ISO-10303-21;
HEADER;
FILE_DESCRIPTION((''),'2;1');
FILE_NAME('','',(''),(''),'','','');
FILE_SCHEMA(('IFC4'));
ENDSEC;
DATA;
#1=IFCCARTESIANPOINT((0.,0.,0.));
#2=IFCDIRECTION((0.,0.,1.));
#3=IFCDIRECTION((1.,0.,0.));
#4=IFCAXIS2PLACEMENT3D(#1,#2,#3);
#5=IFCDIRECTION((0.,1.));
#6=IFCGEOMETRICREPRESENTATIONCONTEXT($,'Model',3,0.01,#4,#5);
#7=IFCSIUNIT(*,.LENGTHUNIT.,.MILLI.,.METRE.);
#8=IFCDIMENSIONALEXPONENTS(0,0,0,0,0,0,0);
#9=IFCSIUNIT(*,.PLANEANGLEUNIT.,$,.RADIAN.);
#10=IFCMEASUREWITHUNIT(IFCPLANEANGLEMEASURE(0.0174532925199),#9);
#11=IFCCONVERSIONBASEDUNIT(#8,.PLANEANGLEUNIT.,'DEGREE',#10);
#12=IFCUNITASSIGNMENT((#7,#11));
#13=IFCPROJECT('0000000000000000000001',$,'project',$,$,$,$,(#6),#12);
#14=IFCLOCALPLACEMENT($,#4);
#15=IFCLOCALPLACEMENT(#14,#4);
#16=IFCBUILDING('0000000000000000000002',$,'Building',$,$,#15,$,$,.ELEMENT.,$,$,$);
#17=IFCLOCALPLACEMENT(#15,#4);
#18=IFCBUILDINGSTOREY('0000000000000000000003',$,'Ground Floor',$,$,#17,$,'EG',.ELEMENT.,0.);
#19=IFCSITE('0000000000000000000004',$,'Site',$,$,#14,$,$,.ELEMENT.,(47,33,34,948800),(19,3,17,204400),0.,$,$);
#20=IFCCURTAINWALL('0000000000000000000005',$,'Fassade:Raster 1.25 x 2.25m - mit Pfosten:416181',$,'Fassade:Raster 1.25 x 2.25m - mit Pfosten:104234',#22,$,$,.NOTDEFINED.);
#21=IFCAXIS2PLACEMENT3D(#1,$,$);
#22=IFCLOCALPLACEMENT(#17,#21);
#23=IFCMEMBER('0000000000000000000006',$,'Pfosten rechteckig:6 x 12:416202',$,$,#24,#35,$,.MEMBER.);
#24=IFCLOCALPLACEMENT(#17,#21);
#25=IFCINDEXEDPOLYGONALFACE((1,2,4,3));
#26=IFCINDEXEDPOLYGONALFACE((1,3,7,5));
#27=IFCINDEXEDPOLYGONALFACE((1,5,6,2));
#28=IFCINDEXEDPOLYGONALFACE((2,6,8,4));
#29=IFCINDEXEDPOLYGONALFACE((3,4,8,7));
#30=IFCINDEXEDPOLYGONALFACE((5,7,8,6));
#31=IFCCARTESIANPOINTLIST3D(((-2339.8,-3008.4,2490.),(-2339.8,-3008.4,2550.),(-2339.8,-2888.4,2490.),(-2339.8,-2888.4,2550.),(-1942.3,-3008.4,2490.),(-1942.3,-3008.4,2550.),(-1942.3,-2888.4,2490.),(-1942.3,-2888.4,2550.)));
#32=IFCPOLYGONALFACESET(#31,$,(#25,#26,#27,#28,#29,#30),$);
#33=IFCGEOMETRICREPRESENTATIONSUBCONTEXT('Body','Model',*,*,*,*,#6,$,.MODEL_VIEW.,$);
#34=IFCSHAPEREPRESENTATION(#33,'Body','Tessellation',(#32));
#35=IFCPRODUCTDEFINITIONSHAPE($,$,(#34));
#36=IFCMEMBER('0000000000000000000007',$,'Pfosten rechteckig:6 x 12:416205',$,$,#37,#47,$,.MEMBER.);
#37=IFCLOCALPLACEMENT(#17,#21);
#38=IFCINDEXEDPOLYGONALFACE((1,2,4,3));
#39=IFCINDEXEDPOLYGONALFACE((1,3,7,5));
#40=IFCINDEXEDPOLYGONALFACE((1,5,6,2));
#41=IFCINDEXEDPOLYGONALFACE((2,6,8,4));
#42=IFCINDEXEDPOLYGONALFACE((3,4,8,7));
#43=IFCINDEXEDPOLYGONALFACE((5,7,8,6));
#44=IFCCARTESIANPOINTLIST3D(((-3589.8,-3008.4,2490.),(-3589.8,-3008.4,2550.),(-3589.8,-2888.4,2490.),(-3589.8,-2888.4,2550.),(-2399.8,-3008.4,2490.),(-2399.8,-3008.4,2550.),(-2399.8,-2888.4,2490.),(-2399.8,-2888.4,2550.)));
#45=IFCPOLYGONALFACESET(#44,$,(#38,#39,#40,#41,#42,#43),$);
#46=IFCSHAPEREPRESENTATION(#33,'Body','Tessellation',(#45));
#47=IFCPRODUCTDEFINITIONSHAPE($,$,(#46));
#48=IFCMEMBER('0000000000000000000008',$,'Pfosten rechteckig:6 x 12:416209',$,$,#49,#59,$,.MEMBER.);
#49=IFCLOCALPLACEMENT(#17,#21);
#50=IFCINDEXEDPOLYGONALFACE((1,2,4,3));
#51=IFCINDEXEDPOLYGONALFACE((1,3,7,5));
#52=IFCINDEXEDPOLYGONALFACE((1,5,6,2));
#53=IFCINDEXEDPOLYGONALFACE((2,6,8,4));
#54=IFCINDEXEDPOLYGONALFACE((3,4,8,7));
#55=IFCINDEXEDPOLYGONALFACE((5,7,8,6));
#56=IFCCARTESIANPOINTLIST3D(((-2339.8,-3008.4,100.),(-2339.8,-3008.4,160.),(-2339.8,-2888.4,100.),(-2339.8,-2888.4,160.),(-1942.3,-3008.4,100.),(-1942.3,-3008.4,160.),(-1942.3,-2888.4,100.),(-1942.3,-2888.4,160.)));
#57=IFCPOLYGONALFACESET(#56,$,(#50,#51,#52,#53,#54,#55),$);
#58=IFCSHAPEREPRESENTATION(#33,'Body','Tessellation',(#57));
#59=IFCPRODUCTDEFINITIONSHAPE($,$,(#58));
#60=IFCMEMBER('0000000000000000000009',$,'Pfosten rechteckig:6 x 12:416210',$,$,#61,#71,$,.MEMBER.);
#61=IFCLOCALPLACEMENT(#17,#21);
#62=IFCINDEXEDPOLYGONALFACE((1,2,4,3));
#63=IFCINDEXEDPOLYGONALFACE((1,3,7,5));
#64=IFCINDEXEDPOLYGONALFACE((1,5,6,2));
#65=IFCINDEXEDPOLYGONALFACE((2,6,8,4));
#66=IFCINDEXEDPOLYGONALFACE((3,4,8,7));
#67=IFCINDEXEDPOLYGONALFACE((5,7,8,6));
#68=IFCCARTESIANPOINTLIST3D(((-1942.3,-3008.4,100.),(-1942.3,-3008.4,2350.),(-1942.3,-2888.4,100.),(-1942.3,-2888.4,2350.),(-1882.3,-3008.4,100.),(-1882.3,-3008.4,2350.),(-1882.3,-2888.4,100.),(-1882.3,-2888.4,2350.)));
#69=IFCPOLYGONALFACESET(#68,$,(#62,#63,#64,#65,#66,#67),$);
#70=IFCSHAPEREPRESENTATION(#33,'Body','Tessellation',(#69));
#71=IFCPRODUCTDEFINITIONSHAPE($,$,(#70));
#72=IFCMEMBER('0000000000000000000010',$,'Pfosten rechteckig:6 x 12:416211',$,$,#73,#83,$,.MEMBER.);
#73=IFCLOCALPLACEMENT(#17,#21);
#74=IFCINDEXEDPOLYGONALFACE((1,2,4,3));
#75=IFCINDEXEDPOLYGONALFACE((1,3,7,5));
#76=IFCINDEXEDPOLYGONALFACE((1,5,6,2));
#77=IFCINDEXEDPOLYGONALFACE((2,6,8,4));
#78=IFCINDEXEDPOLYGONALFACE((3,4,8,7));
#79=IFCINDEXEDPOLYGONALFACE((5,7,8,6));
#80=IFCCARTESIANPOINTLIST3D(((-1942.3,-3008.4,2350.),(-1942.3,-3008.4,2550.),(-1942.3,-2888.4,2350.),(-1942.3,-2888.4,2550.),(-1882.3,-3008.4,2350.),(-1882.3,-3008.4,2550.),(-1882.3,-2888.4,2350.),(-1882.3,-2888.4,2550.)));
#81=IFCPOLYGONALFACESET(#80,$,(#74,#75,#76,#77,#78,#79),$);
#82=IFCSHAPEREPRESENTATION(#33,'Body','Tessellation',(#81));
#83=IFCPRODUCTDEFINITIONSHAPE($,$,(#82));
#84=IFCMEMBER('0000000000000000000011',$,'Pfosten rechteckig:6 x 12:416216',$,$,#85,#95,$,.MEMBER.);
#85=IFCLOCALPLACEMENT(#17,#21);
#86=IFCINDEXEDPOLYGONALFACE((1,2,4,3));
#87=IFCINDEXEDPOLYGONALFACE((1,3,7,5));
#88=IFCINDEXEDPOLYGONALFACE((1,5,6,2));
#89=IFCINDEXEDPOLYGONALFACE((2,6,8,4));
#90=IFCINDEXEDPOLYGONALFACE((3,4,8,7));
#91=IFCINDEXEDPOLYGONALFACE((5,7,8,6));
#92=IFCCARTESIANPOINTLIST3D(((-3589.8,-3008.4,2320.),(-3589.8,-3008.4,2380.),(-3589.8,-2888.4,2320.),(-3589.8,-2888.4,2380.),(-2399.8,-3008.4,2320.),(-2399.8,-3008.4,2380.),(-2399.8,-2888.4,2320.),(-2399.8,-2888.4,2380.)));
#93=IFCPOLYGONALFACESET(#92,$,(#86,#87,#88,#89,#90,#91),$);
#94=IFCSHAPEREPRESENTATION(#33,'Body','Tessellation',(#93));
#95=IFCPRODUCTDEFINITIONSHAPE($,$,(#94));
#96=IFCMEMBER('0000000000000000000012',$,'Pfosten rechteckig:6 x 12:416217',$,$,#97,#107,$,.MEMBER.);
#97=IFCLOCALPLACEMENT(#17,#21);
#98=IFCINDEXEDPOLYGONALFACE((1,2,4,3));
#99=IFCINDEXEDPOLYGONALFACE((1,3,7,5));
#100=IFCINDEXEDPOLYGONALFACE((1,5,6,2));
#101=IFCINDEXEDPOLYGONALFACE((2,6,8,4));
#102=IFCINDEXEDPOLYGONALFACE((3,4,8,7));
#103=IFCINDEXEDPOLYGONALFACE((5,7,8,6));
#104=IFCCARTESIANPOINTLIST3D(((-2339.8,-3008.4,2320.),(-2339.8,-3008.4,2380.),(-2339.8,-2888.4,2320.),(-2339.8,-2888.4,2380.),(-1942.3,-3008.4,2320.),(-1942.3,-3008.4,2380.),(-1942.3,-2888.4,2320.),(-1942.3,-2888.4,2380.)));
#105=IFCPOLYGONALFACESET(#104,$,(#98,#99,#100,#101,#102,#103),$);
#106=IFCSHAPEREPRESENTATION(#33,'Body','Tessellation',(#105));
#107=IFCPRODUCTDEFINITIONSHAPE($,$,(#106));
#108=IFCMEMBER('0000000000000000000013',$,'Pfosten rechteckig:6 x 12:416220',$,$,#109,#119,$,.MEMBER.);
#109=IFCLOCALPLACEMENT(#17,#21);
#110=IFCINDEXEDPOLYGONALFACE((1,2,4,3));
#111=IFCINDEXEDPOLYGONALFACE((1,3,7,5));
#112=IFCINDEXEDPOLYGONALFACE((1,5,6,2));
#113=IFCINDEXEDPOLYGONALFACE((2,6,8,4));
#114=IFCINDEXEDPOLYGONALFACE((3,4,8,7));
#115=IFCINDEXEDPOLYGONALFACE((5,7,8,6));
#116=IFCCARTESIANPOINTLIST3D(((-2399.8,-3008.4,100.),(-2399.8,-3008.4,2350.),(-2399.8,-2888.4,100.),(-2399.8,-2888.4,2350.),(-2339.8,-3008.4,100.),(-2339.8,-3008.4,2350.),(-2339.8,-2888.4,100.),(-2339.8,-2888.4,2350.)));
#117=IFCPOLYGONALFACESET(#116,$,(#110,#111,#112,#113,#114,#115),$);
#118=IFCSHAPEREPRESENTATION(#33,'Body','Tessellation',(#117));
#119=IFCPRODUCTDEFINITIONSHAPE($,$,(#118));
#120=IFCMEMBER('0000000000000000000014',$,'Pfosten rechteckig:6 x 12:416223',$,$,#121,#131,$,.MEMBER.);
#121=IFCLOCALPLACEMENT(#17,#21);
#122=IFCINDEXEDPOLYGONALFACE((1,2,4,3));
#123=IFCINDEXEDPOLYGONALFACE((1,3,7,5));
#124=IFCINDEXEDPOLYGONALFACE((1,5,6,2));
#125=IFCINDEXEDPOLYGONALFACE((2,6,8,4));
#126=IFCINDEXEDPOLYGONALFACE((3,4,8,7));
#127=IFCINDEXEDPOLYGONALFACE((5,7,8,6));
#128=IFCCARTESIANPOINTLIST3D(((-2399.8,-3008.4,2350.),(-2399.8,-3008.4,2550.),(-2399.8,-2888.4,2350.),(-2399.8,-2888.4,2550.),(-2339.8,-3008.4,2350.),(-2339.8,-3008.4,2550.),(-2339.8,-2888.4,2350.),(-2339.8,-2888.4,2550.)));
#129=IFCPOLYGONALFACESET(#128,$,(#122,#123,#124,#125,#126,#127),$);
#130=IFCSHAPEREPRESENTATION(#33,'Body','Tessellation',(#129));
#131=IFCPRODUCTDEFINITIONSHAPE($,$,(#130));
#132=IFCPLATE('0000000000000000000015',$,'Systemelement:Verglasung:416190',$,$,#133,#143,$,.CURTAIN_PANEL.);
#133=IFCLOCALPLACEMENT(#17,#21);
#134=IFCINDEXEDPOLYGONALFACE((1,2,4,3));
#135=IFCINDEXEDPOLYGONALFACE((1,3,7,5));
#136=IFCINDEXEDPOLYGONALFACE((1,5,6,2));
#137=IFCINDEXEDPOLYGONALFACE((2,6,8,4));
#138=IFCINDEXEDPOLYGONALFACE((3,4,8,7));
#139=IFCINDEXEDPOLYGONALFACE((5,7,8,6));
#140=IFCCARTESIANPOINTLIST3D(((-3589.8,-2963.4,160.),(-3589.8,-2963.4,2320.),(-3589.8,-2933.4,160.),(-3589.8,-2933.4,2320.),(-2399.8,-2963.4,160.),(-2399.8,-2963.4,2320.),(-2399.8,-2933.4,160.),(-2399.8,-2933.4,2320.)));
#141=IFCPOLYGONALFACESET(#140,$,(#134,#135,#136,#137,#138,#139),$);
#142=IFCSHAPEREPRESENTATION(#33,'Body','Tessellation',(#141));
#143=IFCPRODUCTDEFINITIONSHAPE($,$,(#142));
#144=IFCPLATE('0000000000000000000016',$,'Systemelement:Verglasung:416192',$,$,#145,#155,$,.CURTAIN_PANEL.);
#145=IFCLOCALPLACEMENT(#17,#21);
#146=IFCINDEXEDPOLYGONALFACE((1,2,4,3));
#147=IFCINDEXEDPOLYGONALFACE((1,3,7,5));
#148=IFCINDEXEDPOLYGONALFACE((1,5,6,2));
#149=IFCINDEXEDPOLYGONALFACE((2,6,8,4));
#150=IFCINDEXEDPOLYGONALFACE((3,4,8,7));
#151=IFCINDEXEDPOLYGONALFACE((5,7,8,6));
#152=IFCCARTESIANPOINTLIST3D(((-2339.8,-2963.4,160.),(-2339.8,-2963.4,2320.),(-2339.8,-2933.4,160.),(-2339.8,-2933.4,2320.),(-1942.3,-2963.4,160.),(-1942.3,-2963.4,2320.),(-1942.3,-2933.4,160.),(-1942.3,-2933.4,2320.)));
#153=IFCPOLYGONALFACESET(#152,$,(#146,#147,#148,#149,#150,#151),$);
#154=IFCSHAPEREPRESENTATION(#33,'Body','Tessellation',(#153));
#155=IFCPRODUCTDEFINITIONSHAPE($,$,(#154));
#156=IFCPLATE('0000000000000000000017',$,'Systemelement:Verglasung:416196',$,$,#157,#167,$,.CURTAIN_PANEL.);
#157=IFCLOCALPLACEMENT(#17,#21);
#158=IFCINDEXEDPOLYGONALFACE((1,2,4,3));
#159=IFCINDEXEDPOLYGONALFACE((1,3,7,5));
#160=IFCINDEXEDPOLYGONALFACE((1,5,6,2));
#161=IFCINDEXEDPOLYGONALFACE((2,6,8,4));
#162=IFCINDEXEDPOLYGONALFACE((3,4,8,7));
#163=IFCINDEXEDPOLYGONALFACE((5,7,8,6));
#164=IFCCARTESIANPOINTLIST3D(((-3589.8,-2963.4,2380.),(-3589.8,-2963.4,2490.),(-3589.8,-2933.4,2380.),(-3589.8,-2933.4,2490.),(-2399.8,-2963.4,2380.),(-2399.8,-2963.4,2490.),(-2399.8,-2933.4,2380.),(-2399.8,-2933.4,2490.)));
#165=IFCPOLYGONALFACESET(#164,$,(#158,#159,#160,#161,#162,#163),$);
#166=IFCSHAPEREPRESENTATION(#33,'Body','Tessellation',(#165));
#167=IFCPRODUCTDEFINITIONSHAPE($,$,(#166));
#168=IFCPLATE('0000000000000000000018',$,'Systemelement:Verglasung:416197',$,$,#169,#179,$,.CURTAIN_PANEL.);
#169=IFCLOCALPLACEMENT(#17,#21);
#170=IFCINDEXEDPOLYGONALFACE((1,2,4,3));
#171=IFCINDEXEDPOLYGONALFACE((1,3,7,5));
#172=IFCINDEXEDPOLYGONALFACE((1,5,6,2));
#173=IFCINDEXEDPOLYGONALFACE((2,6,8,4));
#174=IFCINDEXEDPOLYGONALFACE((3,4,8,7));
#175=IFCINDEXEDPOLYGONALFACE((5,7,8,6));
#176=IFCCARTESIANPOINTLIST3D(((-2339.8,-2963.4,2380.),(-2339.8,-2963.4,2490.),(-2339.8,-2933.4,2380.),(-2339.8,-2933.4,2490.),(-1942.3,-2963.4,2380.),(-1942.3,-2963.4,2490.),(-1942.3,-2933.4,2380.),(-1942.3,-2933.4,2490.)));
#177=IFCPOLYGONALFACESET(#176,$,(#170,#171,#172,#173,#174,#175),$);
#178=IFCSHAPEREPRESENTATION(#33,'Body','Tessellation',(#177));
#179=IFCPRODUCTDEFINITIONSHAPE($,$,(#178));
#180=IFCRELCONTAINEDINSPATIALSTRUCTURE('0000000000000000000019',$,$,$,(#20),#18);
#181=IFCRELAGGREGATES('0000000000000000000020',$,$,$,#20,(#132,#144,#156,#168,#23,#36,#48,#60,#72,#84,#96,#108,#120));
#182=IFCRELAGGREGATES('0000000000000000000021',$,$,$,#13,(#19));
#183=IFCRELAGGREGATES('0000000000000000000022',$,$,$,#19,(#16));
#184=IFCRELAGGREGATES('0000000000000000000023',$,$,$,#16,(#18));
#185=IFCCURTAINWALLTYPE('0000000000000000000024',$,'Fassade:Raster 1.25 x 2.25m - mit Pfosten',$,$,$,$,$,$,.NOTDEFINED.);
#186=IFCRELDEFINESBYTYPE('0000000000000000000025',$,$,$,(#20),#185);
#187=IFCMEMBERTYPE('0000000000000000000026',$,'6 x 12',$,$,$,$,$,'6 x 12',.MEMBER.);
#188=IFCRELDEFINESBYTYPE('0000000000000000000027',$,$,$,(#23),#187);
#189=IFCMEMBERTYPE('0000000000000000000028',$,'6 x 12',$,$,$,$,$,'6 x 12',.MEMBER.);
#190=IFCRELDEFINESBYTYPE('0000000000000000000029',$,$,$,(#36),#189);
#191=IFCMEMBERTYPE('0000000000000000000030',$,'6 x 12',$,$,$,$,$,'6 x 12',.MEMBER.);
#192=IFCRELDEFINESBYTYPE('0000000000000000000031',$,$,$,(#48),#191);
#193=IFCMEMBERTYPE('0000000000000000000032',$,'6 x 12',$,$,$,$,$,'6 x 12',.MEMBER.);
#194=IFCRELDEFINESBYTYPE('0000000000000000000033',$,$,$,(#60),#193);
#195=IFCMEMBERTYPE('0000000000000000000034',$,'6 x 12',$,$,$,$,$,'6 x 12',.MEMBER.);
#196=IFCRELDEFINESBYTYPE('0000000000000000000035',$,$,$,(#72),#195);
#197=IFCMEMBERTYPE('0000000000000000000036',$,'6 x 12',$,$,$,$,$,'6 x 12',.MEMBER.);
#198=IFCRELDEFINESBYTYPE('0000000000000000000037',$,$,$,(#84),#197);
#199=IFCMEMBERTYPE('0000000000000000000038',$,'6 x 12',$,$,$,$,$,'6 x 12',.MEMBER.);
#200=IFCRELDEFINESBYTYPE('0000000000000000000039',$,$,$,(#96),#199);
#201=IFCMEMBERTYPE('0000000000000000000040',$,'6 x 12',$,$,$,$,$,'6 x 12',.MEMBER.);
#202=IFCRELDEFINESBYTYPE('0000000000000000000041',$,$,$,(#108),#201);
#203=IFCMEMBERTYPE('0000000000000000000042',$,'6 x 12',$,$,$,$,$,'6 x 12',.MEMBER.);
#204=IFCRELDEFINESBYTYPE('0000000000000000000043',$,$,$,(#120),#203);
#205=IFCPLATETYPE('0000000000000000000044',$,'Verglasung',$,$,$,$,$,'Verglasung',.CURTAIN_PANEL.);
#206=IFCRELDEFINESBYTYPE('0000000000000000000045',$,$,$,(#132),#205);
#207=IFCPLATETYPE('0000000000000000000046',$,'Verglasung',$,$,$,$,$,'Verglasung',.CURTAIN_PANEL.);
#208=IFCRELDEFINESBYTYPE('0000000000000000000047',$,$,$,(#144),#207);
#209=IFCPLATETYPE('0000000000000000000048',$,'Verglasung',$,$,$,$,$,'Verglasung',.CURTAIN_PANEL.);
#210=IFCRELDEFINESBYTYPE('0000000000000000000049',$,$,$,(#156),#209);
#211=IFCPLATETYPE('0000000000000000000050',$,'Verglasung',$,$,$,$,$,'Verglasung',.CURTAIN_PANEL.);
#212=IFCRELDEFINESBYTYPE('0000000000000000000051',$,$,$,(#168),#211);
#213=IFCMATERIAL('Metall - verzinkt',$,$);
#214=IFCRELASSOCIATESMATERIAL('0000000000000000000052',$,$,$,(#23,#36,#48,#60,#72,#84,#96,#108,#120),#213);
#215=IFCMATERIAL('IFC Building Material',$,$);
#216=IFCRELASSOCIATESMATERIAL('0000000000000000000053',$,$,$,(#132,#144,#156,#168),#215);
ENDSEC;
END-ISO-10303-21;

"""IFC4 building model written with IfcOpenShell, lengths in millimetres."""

from ifc_helpers import new_model, entity, si_unit, converted_unit, direction, frame, origin_with_axes, origin_2d_with_axis, place, context, subcontext, project, spatial, rectangle, extrude, material, type_object, element, aggregate, save


model = new_model("IFC4")

# Units and contexts
model_context = context("Model", 3, precision=0.01, world=origin_with_axes(), true_north=direction((0.0, 1.0)))
body_context = subcontext(model_context, "Body", "Model", "MODEL_VIEW")
ifc_project = project(units=[si_unit("LENGTHUNIT", "METRE", prefix="MILLI"), converted_unit("PLANEANGLEUNIT", "DEGREE", entity("IfcPlaneAngleMeasure", 0.0174532925199), si_unit("PLANEANGLEUNIT", "RADIAN"), dimensions=[0, 0, 0, 0, 0, 0, 0])], contexts=[model_context])

# Site, building, storey
site_placement = place(None, origin_with_axes())
site = spatial("IfcSite", under=ifc_project, at=site_placement, Name="Site", CompositionType="ELEMENT", RefLatitude=(47, 33, 34, 948800), RefLongitude=(19, 3, 17, 204400), RefElevation=0.0)
building_placement = place(site_placement, origin_with_axes())
building = spatial("IfcBuilding", under=site, at=building_placement, Name="Building", CompositionType="ELEMENT")
storey_placement = place(building_placement, origin_with_axes())
storey = spatial("IfcBuildingStorey", under=building, at=storey_placement, Name="Ground Floor", LongName="EG", CompositionType="ELEMENT", Elevation=0.0)

# Curtain wall, members, plates
curtain_wall_type = type_object("IfcCurtainWallType", Name="Fassade:Raster 1.25 x 2.25m - mit Pfosten", PredefinedType="NOTDEFINED")
curtain_wall_placement = place(storey_placement, origin_with_axes())
curtain_wall = element("IfcCurtainWall", 1, at=curtain_wall_placement, inside=storey, type_object=curtain_wall_type, Name="Fassade:Raster 1.25 x 2.25m - mit Pfosten:416181", ObjectType="Fassade:Raster 1.25 x 2.25m - mit Pfosten:104234", PredefinedType="NOTDEFINED")
ifc_material_1 = material(Name="Metall - verzinkt")
member_type_1 = type_object("IfcMemberType", Name="6 x 12", ElementType="6 x 12", PredefinedType="MEMBER")
member_1_placement = place(curtain_wall_placement, frame((-1942.3, -2948.4, 2550.0), z_axis=(0.0, 0.0, 1.0), x_axis=(0.0, -1.0, 0.0)))
member_1 = element("IfcMember", 2, at=member_1_placement, type_object=member_type_1, material=ifc_material_1, Name="Pfosten rechteckig:6 x 12:416202", PredefinedType="MEMBER", context=body_context, shape_type="SweptSolid", body=[
    extrude(rectangle(XDim=120.0, YDim=60.0, at=origin_2d_with_axis()), frame((0.0, -397.5, -30.0), z_axis=(0.0, 1.0, 0.0), x_axis=(-1.0, 0.0, 0.0)), (0.0, 0.0, 1.0), 397.5),
])
member_type_2 = type_object("IfcMemberType", Name="6 x 12", ElementType="6 x 12", PredefinedType="MEMBER")
member_2_placement = place(curtain_wall_placement, frame((-2399.8, -2948.4, 2550.0), z_axis=(0.0, 0.0, 1.0), x_axis=(0.0, -1.0, 0.0)))
member_2 = element("IfcMember", 3, at=member_2_placement, type_object=member_type_2, material=ifc_material_1, Name="Pfosten rechteckig:6 x 12:416205", PredefinedType="MEMBER", context=body_context, shape_type="SweptSolid", body=[
    extrude(rectangle(XDim=120.0, YDim=60.0, at=origin_2d_with_axis()), frame((0.0, -1190.0, -30.0), z_axis=(0.0, 1.0, 0.0), x_axis=(-1.0, 0.0, 0.0)), (0.0, 0.0, 1.0), 1190.0),
])
member_type_3 = type_object("IfcMemberType", Name="6 x 12", ElementType="6 x 12", PredefinedType="MEMBER")
member_3_placement = place(curtain_wall_placement, frame((-2339.8, -2948.4, 100.0), z_axis=(0.0, 0.0, 1.0), x_axis=(0.0, -1.0, 0.0)))
member_3 = element("IfcMember", 4, at=member_3_placement, type_object=member_type_3, material=ifc_material_1, Name="Pfosten rechteckig:6 x 12:416209", PredefinedType="MEMBER", context=body_context, shape_type="SweptSolid", body=[
    extrude(rectangle(XDim=120.0, YDim=60.0, at=origin_2d_with_axis()), frame((0.0, 397.5, 30.0), z_axis=(0.0, -1.0, 0.0), x_axis=(-1.0, 0.0, 0.0)), (0.0, 0.0, 1.0), 397.5),
])
member_type_4 = type_object("IfcMemberType", Name="6 x 12", ElementType="6 x 12", PredefinedType="MEMBER")
member_4_placement = place(curtain_wall_placement, frame((-1882.3, -2948.4, 100.0), z_axis=(0.0, 0.0, 1.0), x_axis=(1.0, 0.0, 0.0)))
member_4 = element("IfcMember", 5, at=member_4_placement, type_object=member_type_4, material=ifc_material_1, Name="Pfosten rechteckig:6 x 12:416210", PredefinedType="MEMBER", context=body_context, shape_type="SweptSolid", body=[
    extrude(rectangle(XDim=120.0, YDim=60.0, at=origin_2d_with_axis()), frame((-30.0, 0.0, 2250.0), z_axis=(0.0, 0.0, -1.0), x_axis=(0.0, 1.0, 0.0)), (0.0, 0.0, 1.0), 2250.0),
])
member_type_5 = type_object("IfcMemberType", Name="6 x 12", ElementType="6 x 12", PredefinedType="MEMBER")
member_5_placement = place(curtain_wall_placement, frame((-1882.3, -2948.4, 2350.0), z_axis=(0.0, 0.0, 1.0), x_axis=(1.0, 0.0, 0.0)))
member_5 = element("IfcMember", 6, at=member_5_placement, type_object=member_type_5, material=ifc_material_1, Name="Pfosten rechteckig:6 x 12:416211", PredefinedType="MEMBER", context=body_context, shape_type="SweptSolid", body=[
    extrude(rectangle(XDim=120.0, YDim=60.0, at=origin_2d_with_axis()), frame((-30.0, 0.0, 200.0), z_axis=(0.0, 0.0, -1.0), x_axis=(0.0, 1.0, 0.0)), (0.0, 0.0, 1.0), 200.0),
])
member_type_6 = type_object("IfcMemberType", Name="6 x 12", ElementType="6 x 12", PredefinedType="MEMBER")
member_6_placement = place(curtain_wall_placement, frame((-2399.8, -2948.4, 2350.0), z_axis=(0.0, 0.0, 1.0), x_axis=(0.0, -1.0, 0.0)))
member_6 = element("IfcMember", 7, at=member_6_placement, type_object=member_type_6, material=ifc_material_1, Name="Pfosten rechteckig:6 x 12:416216", PredefinedType="MEMBER", context=body_context, shape_type="SweptSolid", body=[
    extrude(rectangle(XDim=120.0, YDim=60.0, at=origin_2d_with_axis()), frame((0.0, -1190.0, 0.0), z_axis=(0.0, 1.0, 0.0), x_axis=(-1.0, 0.0, 0.0)), (0.0, 0.0, 1.0), 1190.0),
])
member_type_7 = type_object("IfcMemberType", Name="6 x 12", ElementType="6 x 12", PredefinedType="MEMBER")
member_7_placement = place(curtain_wall_placement, frame((-1942.3, -2948.4, 2350.0), z_axis=(0.0, 0.0, 1.0), x_axis=(0.0, -1.0, 0.0)))
member_7 = element("IfcMember", 8, at=member_7_placement, type_object=member_type_7, material=ifc_material_1, Name="Pfosten rechteckig:6 x 12:416217", PredefinedType="MEMBER", context=body_context, shape_type="SweptSolid", body=[
    extrude(rectangle(XDim=120.0, YDim=60.0, at=origin_2d_with_axis()), frame((0.0, -397.5, 0.0), z_axis=(0.0, 1.0, 0.0), x_axis=(-1.0, 0.0, 0.0)), (0.0, 0.0, 1.0), 397.5),
])
member_type_8 = type_object("IfcMemberType", Name="6 x 12", ElementType="6 x 12", PredefinedType="MEMBER")
member_8_placement = place(curtain_wall_placement, frame((-2369.8, -2948.4, 100.0), z_axis=(0.0, 0.0, 1.0), x_axis=(1.0, 0.0, 0.0)))
member_8 = element("IfcMember", 9, at=member_8_placement, type_object=member_type_8, material=ifc_material_1, Name="Pfosten rechteckig:6 x 12:416220", PredefinedType="MEMBER", context=body_context, shape_type="SweptSolid", body=[
    extrude(rectangle(XDim=120.0, YDim=60.0, at=origin_2d_with_axis()), frame((0.0, 0.0, 2250.0), z_axis=(0.0, 0.0, -1.0), x_axis=(0.0, 1.0, 0.0)), (0.0, 0.0, 1.0), 2250.0),
])
member_type_9 = type_object("IfcMemberType", Name="6 x 12", ElementType="6 x 12", PredefinedType="MEMBER")
member_9_placement = place(curtain_wall_placement, frame((-2369.8, -2948.4, 2350.0), z_axis=(0.0, 0.0, 1.0), x_axis=(1.0, 0.0, 0.0)))
member_9 = element("IfcMember", 10, at=member_9_placement, type_object=member_type_9, material=ifc_material_1, Name="Pfosten rechteckig:6 x 12:416223", PredefinedType="MEMBER", context=body_context, shape_type="SweptSolid", body=[
    extrude(rectangle(XDim=120.0, YDim=60.0, at=origin_2d_with_axis()), frame((0.0, 0.0, 200.0), z_axis=(0.0, 0.0, -1.0), x_axis=(0.0, 1.0, 0.0)), (0.0, 0.0, 1.0), 200.0),
])
ifc_material_2 = material(Name="IFC Building Material")
plate_type_1 = type_object("IfcPlateType", Name="Verglasung", ElementType="Verglasung", PredefinedType="CURTAIN_PANEL")
plate_1_placement = place(curtain_wall_placement, frame((-2994.8, -2948.4, 160.0), z_axis=(0.0, 0.0, 1.0), x_axis=(1.0, 0.0, 0.0)))
plate_1 = element("IfcPlate", 11, at=plate_1_placement, type_object=plate_type_1, material=ifc_material_2, Name="Systemelement:Verglasung:416190", PredefinedType="CURTAIN_PANEL", context=body_context, shape_type="SweptSolid", body=[
    extrude(rectangle(XDim=30.0, YDim=1190.0, at=origin_2d_with_axis()), frame((0.0, 0.0, 0.0), z_axis=(0.0, 0.0, 1.0), x_axis=(0.0, 1.0, 0.0)), (0.0, 0.0, 1.0), 2160.0),
])
plate_type_2 = type_object("IfcPlateType", Name="Verglasung", ElementType="Verglasung", PredefinedType="CURTAIN_PANEL")
plate_2_placement = place(curtain_wall_placement, frame((-2141.0, -2948.4, 160.0), z_axis=(0.0, 0.0, 1.0), x_axis=(1.0, 0.0, 0.0)))
plate_2 = element("IfcPlate", 12, at=plate_2_placement, type_object=plate_type_2, material=ifc_material_2, Name="Systemelement:Verglasung:416192", PredefinedType="CURTAIN_PANEL", context=body_context, shape_type="SweptSolid", body=[
    extrude(rectangle(XDim=30.0, YDim=397.5, at=origin_2d_with_axis()), frame((0.0, 0.0, 0.0), z_axis=(0.0, 0.0, 1.0), x_axis=(0.0, 1.0, 0.0)), (0.0, 0.0, 1.0), 2160.0),
])
plate_type_3 = type_object("IfcPlateType", Name="Verglasung", ElementType="Verglasung", PredefinedType="CURTAIN_PANEL")
plate_3_placement = place(curtain_wall_placement, frame((-2994.8, -2948.4, 2380.0), z_axis=(0.0, 0.0, 1.0), x_axis=(1.0, 0.0, 0.0)))
plate_3 = element("IfcPlate", 13, at=plate_3_placement, type_object=plate_type_3, material=ifc_material_2, Name="Systemelement:Verglasung:416196", PredefinedType="CURTAIN_PANEL", context=body_context, shape_type="SweptSolid", body=[
    extrude(rectangle(XDim=30.0, YDim=1190.0, at=origin_2d_with_axis()), frame((0.0, 0.0, 0.0), z_axis=(0.0, 0.0, 1.0), x_axis=(0.0, 1.0, 0.0)), (0.0, 0.0, 1.0), 110.0),
])
plate_type_4 = type_object("IfcPlateType", Name="Verglasung", ElementType="Verglasung", PredefinedType="CURTAIN_PANEL")
plate_4_placement = place(curtain_wall_placement, frame((-2141.0, -2948.4, 2380.0), z_axis=(0.0, 0.0, 1.0), x_axis=(1.0, 0.0, 0.0)))
plate_4 = element("IfcPlate", 14, at=plate_4_placement, type_object=plate_type_4, material=ifc_material_2, Name="Systemelement:Verglasung:416197", PredefinedType="CURTAIN_PANEL", context=body_context, shape_type="SweptSolid", body=[
    extrude(rectangle(XDim=30.0, YDim=397.5, at=origin_2d_with_axis()), frame((0.0, 0.0, 0.0), z_axis=(0.0, 0.0, 1.0), x_axis=(0.0, 1.0, 0.0)), (0.0, 0.0, 1.0), 110.0),
])
aggregate(curtain_wall, [plate_1, plate_2, plate_3, plate_4, member_1, member_2, member_3, member_4, member_5, member_6, member_7, member_8, member_9])

save(model, "model.ifc")
